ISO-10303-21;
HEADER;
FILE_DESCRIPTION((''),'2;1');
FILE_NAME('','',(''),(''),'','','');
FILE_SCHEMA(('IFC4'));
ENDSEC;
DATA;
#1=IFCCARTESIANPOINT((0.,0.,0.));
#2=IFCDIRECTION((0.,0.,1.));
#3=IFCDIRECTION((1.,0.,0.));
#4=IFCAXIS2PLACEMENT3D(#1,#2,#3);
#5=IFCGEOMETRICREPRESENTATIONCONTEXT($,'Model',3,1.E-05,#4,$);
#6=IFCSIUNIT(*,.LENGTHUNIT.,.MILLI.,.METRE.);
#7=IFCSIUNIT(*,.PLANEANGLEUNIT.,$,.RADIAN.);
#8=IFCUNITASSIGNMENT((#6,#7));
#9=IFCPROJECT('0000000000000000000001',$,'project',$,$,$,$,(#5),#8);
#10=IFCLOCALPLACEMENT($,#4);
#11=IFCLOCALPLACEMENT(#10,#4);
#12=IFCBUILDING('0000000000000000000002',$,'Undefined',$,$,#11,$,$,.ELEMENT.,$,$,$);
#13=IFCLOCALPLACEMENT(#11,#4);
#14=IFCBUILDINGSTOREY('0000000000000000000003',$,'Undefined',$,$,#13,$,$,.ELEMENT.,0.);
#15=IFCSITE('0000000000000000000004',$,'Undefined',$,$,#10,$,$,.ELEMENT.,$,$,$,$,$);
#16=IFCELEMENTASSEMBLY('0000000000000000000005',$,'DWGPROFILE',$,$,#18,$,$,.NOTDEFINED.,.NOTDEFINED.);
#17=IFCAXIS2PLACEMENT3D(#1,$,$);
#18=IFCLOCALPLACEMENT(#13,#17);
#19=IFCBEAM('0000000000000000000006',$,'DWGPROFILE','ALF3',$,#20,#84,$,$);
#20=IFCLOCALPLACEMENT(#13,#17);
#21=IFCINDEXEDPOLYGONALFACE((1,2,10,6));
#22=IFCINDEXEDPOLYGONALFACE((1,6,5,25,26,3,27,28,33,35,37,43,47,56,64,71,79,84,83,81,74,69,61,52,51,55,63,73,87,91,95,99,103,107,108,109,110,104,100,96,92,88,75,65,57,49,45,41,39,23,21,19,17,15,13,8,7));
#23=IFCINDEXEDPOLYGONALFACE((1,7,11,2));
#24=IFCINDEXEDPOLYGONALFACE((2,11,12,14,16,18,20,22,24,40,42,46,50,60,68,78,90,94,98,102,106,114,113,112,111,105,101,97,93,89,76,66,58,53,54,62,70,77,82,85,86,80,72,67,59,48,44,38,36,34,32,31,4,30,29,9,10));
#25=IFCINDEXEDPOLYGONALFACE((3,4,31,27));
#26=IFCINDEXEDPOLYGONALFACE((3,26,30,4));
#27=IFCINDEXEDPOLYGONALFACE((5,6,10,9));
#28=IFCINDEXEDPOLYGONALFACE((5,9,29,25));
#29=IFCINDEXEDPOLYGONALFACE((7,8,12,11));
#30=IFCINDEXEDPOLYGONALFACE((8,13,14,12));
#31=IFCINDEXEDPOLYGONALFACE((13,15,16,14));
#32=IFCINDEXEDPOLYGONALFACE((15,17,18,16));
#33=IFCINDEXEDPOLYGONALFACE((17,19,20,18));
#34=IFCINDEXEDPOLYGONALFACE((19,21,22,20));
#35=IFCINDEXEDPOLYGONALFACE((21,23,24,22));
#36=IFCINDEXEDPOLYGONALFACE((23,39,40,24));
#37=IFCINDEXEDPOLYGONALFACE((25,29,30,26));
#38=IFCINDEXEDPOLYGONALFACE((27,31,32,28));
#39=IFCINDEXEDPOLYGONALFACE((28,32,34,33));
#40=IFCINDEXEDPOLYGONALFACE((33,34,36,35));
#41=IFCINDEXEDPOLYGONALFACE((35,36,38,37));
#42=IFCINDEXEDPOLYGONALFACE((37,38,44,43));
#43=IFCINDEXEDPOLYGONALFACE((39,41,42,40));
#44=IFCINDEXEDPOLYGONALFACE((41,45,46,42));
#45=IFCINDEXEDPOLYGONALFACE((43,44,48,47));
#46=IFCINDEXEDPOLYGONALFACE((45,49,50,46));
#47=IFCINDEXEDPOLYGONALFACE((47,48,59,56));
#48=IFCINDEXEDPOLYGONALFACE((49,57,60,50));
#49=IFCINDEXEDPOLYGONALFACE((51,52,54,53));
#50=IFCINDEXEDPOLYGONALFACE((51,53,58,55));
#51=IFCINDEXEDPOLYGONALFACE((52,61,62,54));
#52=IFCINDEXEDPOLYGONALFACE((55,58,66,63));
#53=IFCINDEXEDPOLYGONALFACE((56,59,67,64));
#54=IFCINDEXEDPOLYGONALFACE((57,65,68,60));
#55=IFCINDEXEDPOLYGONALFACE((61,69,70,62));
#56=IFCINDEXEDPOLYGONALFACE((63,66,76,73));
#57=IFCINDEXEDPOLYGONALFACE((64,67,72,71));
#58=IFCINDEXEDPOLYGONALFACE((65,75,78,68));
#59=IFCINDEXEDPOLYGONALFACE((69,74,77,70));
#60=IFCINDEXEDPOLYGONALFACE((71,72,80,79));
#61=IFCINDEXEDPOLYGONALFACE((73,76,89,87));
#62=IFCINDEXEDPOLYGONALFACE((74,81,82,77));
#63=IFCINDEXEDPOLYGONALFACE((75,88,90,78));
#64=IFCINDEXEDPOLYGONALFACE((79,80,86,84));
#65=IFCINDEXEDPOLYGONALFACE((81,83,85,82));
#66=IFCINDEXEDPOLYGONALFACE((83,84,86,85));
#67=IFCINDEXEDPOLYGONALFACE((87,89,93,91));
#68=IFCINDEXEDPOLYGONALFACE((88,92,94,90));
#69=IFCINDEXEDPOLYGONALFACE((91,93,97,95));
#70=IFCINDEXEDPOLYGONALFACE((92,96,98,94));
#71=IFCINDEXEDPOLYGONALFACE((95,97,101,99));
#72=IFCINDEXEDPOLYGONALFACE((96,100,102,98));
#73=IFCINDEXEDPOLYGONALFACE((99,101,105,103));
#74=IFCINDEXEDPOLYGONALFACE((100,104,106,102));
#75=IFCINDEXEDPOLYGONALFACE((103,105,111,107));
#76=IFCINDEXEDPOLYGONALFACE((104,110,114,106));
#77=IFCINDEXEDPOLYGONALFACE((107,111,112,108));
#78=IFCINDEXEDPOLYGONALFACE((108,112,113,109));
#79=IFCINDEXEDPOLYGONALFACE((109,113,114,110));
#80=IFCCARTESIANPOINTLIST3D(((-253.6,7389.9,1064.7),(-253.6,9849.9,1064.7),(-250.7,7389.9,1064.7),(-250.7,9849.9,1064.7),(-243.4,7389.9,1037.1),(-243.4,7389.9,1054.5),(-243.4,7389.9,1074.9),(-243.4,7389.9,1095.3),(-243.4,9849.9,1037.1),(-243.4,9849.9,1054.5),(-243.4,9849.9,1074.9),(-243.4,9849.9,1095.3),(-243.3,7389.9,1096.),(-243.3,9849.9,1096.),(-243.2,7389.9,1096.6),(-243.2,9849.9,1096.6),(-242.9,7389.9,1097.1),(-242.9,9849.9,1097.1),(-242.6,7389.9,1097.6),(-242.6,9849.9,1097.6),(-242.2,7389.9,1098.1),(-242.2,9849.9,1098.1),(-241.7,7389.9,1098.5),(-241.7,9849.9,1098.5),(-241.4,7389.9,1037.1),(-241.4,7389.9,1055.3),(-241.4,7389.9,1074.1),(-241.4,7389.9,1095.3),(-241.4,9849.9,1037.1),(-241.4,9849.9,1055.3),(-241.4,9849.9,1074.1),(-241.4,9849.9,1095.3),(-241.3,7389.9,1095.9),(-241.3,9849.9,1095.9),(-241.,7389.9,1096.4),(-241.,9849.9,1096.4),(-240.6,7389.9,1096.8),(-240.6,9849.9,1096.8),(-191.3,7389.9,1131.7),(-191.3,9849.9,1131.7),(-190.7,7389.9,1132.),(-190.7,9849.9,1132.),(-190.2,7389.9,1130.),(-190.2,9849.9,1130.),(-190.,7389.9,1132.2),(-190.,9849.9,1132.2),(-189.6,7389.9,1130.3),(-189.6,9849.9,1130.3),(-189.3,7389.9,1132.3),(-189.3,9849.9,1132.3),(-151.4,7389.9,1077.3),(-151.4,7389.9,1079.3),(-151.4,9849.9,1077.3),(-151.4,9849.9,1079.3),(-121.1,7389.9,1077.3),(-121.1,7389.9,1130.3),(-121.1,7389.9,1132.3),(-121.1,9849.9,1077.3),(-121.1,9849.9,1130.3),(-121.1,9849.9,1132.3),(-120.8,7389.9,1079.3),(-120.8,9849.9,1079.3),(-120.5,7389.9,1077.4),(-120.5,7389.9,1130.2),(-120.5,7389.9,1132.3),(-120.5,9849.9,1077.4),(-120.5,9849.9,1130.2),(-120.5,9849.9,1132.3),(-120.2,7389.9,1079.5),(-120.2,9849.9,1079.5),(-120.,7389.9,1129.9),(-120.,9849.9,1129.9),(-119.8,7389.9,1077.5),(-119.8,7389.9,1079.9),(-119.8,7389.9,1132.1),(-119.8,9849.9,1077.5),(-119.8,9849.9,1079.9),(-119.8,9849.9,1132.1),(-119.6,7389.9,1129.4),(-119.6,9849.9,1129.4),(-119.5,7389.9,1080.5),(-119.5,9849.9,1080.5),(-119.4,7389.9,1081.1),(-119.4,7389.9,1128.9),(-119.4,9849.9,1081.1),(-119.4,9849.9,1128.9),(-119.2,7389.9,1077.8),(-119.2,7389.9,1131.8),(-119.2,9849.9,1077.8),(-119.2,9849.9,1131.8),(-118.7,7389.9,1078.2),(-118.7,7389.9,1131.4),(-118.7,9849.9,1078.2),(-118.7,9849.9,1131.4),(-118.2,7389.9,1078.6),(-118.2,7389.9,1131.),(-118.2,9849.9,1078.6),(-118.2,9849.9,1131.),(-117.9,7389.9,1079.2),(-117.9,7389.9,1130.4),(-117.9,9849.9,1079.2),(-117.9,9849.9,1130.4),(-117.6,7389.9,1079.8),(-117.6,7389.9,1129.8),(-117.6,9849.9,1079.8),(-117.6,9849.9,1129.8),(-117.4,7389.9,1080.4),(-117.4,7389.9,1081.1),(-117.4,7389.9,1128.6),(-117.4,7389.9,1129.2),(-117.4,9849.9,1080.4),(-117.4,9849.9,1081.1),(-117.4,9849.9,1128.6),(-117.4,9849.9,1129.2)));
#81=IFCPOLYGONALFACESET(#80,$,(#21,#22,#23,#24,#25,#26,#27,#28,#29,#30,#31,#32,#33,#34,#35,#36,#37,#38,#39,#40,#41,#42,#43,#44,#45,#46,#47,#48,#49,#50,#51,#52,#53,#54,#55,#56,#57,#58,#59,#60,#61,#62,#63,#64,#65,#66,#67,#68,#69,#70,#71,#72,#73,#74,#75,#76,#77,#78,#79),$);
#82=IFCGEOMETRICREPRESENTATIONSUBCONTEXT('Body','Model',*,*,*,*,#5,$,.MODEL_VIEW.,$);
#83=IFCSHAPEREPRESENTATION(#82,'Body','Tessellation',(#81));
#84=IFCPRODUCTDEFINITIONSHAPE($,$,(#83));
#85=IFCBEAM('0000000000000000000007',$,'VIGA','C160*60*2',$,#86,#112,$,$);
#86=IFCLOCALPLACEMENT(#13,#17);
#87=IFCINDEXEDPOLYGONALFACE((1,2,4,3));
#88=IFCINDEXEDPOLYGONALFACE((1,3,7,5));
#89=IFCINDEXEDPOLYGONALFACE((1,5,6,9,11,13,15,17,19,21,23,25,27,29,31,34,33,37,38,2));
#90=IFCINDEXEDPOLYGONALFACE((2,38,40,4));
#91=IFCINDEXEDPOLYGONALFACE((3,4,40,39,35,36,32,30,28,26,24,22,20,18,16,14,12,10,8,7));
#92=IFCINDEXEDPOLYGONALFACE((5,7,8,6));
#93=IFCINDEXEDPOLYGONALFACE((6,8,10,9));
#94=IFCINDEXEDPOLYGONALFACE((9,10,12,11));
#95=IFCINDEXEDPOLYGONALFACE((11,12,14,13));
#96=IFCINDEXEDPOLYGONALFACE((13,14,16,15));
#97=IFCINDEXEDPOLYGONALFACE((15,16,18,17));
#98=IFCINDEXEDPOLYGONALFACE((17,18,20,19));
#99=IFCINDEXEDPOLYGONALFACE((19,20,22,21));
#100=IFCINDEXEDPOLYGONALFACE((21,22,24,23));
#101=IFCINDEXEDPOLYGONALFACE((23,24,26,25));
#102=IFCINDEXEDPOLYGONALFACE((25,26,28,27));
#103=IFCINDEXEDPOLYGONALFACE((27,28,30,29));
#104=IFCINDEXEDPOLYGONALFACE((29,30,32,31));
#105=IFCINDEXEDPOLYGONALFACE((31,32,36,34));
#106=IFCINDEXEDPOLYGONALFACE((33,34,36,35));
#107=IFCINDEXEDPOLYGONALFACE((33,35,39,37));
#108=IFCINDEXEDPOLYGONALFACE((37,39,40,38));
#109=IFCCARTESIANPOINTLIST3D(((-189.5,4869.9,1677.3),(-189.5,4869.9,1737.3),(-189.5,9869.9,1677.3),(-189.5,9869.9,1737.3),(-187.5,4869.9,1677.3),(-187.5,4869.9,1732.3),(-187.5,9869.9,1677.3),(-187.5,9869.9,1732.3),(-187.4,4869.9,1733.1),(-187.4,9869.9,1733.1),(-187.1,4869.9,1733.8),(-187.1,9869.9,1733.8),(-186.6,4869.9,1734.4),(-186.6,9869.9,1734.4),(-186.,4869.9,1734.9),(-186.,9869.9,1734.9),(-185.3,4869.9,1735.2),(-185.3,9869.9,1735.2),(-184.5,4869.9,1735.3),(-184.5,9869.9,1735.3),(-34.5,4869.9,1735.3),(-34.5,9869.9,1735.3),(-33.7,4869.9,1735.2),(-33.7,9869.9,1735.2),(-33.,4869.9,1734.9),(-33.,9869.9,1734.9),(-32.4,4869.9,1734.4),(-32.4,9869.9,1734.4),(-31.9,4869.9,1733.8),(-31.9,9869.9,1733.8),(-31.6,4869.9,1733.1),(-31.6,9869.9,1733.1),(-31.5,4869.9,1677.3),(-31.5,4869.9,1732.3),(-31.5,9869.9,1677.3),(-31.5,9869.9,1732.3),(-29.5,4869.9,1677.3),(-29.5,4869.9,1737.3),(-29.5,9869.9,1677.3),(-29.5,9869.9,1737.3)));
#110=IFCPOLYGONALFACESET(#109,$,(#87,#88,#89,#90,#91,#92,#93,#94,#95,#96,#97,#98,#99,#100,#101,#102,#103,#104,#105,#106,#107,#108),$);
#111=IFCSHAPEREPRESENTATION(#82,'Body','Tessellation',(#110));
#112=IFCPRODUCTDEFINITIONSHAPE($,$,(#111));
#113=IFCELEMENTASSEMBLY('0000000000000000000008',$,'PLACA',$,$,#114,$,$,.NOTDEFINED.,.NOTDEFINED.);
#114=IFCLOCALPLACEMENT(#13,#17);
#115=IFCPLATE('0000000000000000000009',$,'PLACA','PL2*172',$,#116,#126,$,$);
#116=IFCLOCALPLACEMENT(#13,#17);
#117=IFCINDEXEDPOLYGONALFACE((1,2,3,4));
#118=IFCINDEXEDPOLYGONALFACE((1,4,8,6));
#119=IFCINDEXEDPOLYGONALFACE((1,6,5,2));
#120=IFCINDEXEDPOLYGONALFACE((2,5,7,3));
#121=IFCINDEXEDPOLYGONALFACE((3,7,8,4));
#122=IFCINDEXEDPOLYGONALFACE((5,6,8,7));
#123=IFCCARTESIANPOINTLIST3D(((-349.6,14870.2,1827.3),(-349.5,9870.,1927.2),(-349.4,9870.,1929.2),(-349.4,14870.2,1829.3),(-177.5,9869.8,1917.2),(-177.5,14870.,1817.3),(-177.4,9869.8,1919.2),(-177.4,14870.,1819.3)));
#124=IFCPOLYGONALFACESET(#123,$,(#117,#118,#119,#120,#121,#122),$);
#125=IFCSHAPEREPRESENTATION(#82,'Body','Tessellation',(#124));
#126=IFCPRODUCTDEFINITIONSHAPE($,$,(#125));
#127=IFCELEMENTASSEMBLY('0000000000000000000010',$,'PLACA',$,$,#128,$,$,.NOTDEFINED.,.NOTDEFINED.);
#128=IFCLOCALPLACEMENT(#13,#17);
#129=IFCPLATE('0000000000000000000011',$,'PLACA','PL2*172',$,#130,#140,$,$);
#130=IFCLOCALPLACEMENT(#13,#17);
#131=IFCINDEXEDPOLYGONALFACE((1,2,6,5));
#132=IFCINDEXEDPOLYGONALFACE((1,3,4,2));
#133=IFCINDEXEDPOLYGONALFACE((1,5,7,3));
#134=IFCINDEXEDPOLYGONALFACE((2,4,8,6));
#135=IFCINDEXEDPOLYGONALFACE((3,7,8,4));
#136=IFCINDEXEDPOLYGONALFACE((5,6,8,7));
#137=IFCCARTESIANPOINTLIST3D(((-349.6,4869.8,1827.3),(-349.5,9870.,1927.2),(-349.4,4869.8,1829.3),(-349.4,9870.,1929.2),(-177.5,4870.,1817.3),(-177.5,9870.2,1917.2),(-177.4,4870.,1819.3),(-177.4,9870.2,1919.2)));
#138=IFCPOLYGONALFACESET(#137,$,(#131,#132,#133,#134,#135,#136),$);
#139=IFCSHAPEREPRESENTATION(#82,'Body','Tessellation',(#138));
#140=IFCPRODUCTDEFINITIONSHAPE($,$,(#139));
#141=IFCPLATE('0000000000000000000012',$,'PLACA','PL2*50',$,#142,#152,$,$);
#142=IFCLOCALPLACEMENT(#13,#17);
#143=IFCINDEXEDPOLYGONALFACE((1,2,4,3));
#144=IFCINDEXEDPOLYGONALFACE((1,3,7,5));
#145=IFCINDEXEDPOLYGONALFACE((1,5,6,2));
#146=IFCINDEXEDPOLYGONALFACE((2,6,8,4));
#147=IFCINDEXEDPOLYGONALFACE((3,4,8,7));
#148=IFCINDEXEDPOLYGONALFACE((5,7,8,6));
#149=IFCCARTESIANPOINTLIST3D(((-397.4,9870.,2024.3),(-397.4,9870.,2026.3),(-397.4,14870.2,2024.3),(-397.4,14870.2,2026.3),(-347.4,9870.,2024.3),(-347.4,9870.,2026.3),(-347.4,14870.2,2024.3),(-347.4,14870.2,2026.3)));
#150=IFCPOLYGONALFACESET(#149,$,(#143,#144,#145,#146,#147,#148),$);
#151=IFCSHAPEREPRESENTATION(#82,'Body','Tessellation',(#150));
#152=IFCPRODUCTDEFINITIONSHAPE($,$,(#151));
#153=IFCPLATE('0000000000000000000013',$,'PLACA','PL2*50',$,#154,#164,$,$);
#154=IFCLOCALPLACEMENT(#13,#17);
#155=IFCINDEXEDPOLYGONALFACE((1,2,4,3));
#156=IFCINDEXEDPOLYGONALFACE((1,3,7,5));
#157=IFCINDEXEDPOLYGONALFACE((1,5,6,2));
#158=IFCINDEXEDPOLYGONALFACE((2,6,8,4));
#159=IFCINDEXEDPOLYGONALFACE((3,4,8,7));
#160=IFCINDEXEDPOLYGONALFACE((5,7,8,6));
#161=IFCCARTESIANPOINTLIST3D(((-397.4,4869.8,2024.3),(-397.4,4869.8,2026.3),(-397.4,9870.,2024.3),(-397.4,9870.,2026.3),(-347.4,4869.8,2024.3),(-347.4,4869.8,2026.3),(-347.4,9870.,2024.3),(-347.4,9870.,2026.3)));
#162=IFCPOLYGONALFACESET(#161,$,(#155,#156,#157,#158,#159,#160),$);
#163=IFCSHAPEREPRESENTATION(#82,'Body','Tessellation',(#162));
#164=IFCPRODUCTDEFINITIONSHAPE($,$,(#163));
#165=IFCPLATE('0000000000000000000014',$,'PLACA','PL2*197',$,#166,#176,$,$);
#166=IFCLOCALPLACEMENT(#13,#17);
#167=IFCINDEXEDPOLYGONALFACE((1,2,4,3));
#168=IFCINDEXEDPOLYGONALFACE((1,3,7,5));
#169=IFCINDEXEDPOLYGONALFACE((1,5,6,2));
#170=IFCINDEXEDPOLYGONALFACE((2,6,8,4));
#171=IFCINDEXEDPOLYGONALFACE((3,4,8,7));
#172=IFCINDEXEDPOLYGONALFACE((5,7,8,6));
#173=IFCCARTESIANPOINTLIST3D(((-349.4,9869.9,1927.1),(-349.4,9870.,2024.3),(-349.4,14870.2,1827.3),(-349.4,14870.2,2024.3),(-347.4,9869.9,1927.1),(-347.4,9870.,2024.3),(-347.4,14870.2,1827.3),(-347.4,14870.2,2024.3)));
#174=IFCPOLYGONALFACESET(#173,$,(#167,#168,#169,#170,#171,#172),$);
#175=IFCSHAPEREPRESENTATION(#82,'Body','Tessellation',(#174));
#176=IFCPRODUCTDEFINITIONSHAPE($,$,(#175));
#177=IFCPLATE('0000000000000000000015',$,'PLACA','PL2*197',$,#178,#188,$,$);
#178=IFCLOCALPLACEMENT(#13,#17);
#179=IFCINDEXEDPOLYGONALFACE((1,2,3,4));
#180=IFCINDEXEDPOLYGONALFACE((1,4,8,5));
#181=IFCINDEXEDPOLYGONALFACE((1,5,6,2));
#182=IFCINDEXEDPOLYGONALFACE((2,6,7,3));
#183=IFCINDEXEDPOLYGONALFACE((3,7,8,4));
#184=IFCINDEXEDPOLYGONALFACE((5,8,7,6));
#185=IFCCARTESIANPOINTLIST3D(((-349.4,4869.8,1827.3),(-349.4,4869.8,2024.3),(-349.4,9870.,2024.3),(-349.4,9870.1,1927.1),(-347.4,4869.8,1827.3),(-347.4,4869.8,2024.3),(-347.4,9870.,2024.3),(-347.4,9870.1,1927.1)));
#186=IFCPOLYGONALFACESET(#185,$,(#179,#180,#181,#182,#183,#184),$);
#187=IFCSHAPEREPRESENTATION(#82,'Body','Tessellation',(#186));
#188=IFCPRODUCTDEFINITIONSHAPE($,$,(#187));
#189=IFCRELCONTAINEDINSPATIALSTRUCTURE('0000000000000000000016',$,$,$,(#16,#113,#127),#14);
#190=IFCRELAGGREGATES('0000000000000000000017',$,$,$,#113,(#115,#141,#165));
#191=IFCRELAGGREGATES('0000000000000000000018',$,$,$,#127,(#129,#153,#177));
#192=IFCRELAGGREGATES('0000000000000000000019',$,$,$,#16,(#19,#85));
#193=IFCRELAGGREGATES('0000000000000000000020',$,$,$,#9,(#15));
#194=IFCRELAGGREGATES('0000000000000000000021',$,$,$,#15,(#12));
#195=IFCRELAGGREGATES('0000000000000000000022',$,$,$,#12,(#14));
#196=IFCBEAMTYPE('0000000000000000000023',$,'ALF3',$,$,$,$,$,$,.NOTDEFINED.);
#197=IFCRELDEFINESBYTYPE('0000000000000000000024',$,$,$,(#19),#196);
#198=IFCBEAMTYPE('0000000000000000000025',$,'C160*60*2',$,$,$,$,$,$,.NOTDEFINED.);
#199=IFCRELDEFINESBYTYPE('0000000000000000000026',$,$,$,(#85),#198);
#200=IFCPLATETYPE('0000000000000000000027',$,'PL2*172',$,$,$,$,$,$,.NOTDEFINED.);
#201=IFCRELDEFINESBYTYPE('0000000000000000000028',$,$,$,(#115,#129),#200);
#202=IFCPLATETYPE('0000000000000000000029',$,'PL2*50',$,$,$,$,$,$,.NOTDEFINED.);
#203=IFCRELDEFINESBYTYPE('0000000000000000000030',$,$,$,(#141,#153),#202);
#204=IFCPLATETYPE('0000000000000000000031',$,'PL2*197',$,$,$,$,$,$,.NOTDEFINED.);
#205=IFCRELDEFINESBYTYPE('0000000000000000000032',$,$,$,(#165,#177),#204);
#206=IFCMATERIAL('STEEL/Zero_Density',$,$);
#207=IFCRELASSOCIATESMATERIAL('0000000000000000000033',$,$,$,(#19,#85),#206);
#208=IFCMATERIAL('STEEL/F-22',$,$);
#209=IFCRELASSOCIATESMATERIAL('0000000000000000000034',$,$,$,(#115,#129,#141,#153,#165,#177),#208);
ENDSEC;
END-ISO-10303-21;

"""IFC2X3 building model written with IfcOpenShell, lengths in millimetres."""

from ifc_helpers import new_model, si_unit, frame, origin_with_axes, origin_2d_with_axis, place, context, subcontext, project, spatial, polyline, u_section, outline, extrude, material, type_object, element, aggregate, save


model = new_model("IFC2X3")

# Units and contexts
model_context = context("Model", 3, precision=1e-05, world=origin_with_axes())
body_context = subcontext(model_context, "Body", "Model", "MODEL_VIEW")
ifc_project = project(units=[si_unit("LENGTHUNIT", "METRE", prefix="MILLI"), si_unit("PLANEANGLEUNIT", "RADIAN")], contexts=[model_context])

# Site, building, storey
site_placement = place(None, origin_with_axes())
site = spatial("IfcSite", under=ifc_project, at=site_placement, Name="Undefined", CompositionType="ELEMENT")
building_placement = place(site_placement, origin_with_axes())
building = spatial("IfcBuilding", under=site, at=building_placement, Name="Undefined", CompositionType="ELEMENT")
storey_placement = place(building_placement, origin_with_axes())
storey = spatial("IfcBuildingStorey", under=building, at=storey_placement, Name="Undefined", CompositionType="ELEMENT", Elevation=0.0)

# Shared definitions
ifc_material_1 = material(Name="STEEL/Zero_Density")

# Element assembly, beams
assembly_1_placement = place(storey_placement, origin_with_axes())
assembly_1 = element("IfcElementAssembly", 1, at=assembly_1_placement, inside=storey, Name="DWGPROFILE", AssemblyPlace="NOTDEFINED", PredefinedType="NOTDEFINED")
beam_type_1 = type_object("IfcBeamType", Name="ALF3", PredefinedType="NOTDEFINED")
beam_1_placement = place(assembly_1_placement, frame((-185.5, 9849.9, 1084.7), z_axis=(0.0, 0.0, 1.0), x_axis=(0.0, -1.0, 0.0)))
beam_1 = element("IfcBeam", 2, at=beam_1_placement, type_object=beam_type_1, material=ifc_material_1, Name="DWGPROFILE", Description="ALF3", context=body_context, shape_type="SweptSolid", body=[
    extrude(outline(polyline([(57.9, 10.6), (57.9, -9.8), (68.1, -20.0), (57.9, -30.2), (57.9, -47.6), (55.9, -47.6), (55.9, -29.4), (65.3, -20.0), (55.9, -10.6), (55.9, 10.6), (55.8, 11.2), (55.5, 11.7), (55.1, 12.1), (4.8, 45.3), (4.1, 45.6), (-64.3, 45.6), (-64.9, 45.5), (-65.5, 45.2), (-65.9, 44.7), (-66.1, 44.2), (-66.1, -3.6), (-66.0, -4.2), (-65.7, -4.8), (-65.2, -5.2), (-64.7, -5.4), (-34.1, -5.4), (-34.1, -7.4), (-64.3, -7.4), (-65.0, -7.3), (-65.6, -7.2), (-66.2, -6.9), (-66.8, -6.5), (-67.2, -6.1), (-67.6, -5.5), (-67.9, -4.9), (-68.0, -4.3), (-68.1, -3.6), (-68.1, 43.9), (-68.0, 44.5), (-67.9, 45.1), (-67.6, 45.7), (-67.2, 46.3), (-66.8, 46.7), (-66.2, 47.1), (-65.6, 47.4), (-65.0, 47.5), (-64.3, 47.6), (3.8, 47.6), (4.5, 47.5), (5.2, 47.3), (5.9, 47.0), (56.2, 13.8), (56.7, 13.4), (57.1, 12.9), (57.5, 12.4), (57.7, 11.9), (57.9, 11.3), (57.9, 10.6)])), frame((2460.0, 0.0, 0.0), z_axis=(-1.0, 0.0, 0.0), x_axis=(0.0, -1.0, 0.0)), (0.0, 0.0, 1.0), 2460.0),
])
beam_type_2 = type_object("IfcBeamType", Name="C160*60*2", PredefinedType="NOTDEFINED")
beam_2_placement = place(assembly_1_placement, frame((-109.5, 9869.9, 1707.3), z_axis=(-1.0, 0.0, 0.0), x_axis=(0.0, -1.0, 0.0)))
beam_2 = element("IfcBeam", 3, at=beam_2_placement, type_object=beam_type_2, material=ifc_material_1, Name="VIGA", Description="C160*60*2", context=body_context, shape_type="SweptSolid", body=[
    extrude(u_section(Depth=160.0, FlangeWidth=60.0, WebThickness=2.0, FlangeThickness=2.0, FilletRadius=3.0, at=origin_2d_with_axis()), frame((5000.0, 0.0, 0.0), z_axis=(-1.0, 0.0, 0.0), x_axis=(0.0, -1.0, 0.0)), (0.0, 0.0, 1.0), 5000.0),
])

# Element assemblies, plates
assembly_2_placement = place(storey_placement, origin_with_axes())
assembly_2 = element("IfcElementAssembly", 4, at=assembly_2_placement, inside=storey, Name="PLACA", AssemblyPlace="NOTDEFINED", PredefinedType="NOTDEFINED")
ifc_material_2 = material(Name="STEEL/F-22")
plate_type_1 = type_object("IfcPlateType", Name="PL2*172", PredefinedType="NOTDEFINED")
plate_1_placement = place(assembly_2_placement, frame((-349.5, 9870.0, 1928.2), z_axis=(0.058133, 0.01995, 0.99811), x_axis=(0.998309, -0.001162, -0.058121)))
plate_1 = element("IfcPlate", 5, at=plate_1_placement, type_object=plate_type_1, material=ifc_material_2, Name="PLACA", Description="PL2*172", context=body_context, shape_type="SweptSolid", body=[
    extrude(outline(polyline([(0.0, 0.0), (172.3, 0.0), (172.3, 5001.2), (0.0, 5001.2), (0.0, 0.0)])), frame((0.0, 0.0, -1.0), z_axis=(0.0, 0.0, 1.0), x_axis=(1.0, 0.0, 0.0)), (0.0, 0.0, 1.0), 2.0),
])
assembly_3_placement = place(storey_placement, origin_with_axes())
assembly_3 = element("IfcElementAssembly", 6, at=assembly_3_placement, inside=storey, Name="PLACA", AssemblyPlace="NOTDEFINED", PredefinedType="NOTDEFINED")
plate_2_placement = place(assembly_3_placement, frame((-349.5, 9870.0, 1928.2), z_axis=(-0.058133, 0.01995, -0.99811), x_axis=(0.998309, 0.001162, -0.058121)))
plate_2 = element("IfcPlate", 7, at=plate_2_placement, type_object=plate_type_1, material=ifc_material_2, Name="PLACA", Description="PL2*172", context=body_context, shape_type="SweptSolid", body=[
    extrude(outline(polyline([(0.0, 0.0), (172.3, 0.0), (172.3, 5001.2), (0.0, 5001.2), (0.0, 0.0)])), frame((0.0, 0.0, -1.0), z_axis=(0.0, 0.0, 1.0), x_axis=(1.0, 0.0, 0.0)), (0.0, 0.0, 1.0), 2.0),
])

# Plates
plate_type_2 = type_object("IfcPlateType", Name="PL2*50", PredefinedType="NOTDEFINED")
plate_3_placement = place(assembly_2_placement, frame((-347.4, 9870.0, 2025.3), z_axis=(0.0, 0.000001, -1.0), x_axis=(-1.0, 0.0, 0.0)))
plate_3 = element("IfcPlate", 8, at=plate_3_placement, type_object=plate_type_2, material=ifc_material_2, Name="PLACA", Description="PL2*50", context=body_context, shape_type="SweptSolid", body=[
    extrude(outline(polyline([(0.0, 0.0), (50.0, 0.0), (50.0, 5000.2), (0.0, 5000.2), (0.0, 0.0)])), frame((0.0, 0.0, -1.0), z_axis=(0.0, 0.0, 1.0), x_axis=(1.0, 0.0, 0.0)), (0.0, 0.0, 1.0), 2.0),
])
plate_4_placement = place(assembly_3_placement, frame((-347.4, 9870.0, 2025.3), z_axis=(0.0, 0.0, 1.0), x_axis=(-1.0, 0.0, 0.0)))
plate_4 = element("IfcPlate", 9, at=plate_4_placement, type_object=plate_type_2, material=ifc_material_2, Name="PLACA", Description="PL2*50", context=body_context, shape_type="SweptSolid", body=[
    extrude(outline(polyline([(0.0, 0.0), (50.0, 0.0), (50.0, 5000.2), (0.0, 5000.2), (0.0, 0.0)])), frame((0.0, 0.0, -1.0), z_axis=(0.0, 0.0, 1.0), x_axis=(1.0, 0.0, 0.0)), (0.0, 0.0, 1.0), 2.0),
])
plate_type_3 = type_object("IfcPlateType", Name="PL2*197", PredefinedType="NOTDEFINED")
plate_5_placement = place(assembly_2_placement, frame((-348.4, 9870.0, 2024.3), z_axis=(1.0, 0.0, 0.0), x_axis=(0.0, -0.000827, -1.0)))
plate_5 = element("IfcPlate", 10, at=plate_5_placement, type_object=plate_type_3, material=ifc_material_2, Name="PLACA", Description="PL2*197", context=body_context, shape_type="SweptSolid", body=[
    extrude(outline(polyline([(0.0, 0.0), (97.2, 0.0), (192.9, 5000.4), (-4.1, 5000.2), (0.0, 0.0)])), frame((0.0, 0.0, -1.0), z_axis=(0.0, 0.0, 1.0), x_axis=(1.0, 0.0, 0.0)), (0.0, 0.0, 1.0), 2.0),
])
aggregate(assembly_2, [plate_1, plate_3, plate_5])
plate_6_placement = place(assembly_3_placement, frame((-348.4, 9870.0, 2024.3), z_axis=(-1.0, 0.0, 0.0), x_axis=(0.0, 0.000827, -1.0)))
plate_6 = element("IfcPlate", 11, at=plate_6_placement, type_object=plate_type_3, material=ifc_material_2, Name="PLACA", Description="PL2*197", context=body_context, shape_type="SweptSolid", body=[
    extrude(outline(polyline([(0.0, 0.0), (97.2, 0.0), (192.9, 5000.4), (-4.1, 5000.2), (0.0, 0.0)])), frame((0.0, 0.0, -1.0), z_axis=(0.0, 0.0, 1.0), x_axis=(1.0, 0.0, 0.0)), (0.0, 0.0, 1.0), 2.0),
])
aggregate(assembly_3, [plate_2, plate_4, plate_6])

aggregate(assembly_1, [beam_1, beam_2])

save(model, "model.ifc")
